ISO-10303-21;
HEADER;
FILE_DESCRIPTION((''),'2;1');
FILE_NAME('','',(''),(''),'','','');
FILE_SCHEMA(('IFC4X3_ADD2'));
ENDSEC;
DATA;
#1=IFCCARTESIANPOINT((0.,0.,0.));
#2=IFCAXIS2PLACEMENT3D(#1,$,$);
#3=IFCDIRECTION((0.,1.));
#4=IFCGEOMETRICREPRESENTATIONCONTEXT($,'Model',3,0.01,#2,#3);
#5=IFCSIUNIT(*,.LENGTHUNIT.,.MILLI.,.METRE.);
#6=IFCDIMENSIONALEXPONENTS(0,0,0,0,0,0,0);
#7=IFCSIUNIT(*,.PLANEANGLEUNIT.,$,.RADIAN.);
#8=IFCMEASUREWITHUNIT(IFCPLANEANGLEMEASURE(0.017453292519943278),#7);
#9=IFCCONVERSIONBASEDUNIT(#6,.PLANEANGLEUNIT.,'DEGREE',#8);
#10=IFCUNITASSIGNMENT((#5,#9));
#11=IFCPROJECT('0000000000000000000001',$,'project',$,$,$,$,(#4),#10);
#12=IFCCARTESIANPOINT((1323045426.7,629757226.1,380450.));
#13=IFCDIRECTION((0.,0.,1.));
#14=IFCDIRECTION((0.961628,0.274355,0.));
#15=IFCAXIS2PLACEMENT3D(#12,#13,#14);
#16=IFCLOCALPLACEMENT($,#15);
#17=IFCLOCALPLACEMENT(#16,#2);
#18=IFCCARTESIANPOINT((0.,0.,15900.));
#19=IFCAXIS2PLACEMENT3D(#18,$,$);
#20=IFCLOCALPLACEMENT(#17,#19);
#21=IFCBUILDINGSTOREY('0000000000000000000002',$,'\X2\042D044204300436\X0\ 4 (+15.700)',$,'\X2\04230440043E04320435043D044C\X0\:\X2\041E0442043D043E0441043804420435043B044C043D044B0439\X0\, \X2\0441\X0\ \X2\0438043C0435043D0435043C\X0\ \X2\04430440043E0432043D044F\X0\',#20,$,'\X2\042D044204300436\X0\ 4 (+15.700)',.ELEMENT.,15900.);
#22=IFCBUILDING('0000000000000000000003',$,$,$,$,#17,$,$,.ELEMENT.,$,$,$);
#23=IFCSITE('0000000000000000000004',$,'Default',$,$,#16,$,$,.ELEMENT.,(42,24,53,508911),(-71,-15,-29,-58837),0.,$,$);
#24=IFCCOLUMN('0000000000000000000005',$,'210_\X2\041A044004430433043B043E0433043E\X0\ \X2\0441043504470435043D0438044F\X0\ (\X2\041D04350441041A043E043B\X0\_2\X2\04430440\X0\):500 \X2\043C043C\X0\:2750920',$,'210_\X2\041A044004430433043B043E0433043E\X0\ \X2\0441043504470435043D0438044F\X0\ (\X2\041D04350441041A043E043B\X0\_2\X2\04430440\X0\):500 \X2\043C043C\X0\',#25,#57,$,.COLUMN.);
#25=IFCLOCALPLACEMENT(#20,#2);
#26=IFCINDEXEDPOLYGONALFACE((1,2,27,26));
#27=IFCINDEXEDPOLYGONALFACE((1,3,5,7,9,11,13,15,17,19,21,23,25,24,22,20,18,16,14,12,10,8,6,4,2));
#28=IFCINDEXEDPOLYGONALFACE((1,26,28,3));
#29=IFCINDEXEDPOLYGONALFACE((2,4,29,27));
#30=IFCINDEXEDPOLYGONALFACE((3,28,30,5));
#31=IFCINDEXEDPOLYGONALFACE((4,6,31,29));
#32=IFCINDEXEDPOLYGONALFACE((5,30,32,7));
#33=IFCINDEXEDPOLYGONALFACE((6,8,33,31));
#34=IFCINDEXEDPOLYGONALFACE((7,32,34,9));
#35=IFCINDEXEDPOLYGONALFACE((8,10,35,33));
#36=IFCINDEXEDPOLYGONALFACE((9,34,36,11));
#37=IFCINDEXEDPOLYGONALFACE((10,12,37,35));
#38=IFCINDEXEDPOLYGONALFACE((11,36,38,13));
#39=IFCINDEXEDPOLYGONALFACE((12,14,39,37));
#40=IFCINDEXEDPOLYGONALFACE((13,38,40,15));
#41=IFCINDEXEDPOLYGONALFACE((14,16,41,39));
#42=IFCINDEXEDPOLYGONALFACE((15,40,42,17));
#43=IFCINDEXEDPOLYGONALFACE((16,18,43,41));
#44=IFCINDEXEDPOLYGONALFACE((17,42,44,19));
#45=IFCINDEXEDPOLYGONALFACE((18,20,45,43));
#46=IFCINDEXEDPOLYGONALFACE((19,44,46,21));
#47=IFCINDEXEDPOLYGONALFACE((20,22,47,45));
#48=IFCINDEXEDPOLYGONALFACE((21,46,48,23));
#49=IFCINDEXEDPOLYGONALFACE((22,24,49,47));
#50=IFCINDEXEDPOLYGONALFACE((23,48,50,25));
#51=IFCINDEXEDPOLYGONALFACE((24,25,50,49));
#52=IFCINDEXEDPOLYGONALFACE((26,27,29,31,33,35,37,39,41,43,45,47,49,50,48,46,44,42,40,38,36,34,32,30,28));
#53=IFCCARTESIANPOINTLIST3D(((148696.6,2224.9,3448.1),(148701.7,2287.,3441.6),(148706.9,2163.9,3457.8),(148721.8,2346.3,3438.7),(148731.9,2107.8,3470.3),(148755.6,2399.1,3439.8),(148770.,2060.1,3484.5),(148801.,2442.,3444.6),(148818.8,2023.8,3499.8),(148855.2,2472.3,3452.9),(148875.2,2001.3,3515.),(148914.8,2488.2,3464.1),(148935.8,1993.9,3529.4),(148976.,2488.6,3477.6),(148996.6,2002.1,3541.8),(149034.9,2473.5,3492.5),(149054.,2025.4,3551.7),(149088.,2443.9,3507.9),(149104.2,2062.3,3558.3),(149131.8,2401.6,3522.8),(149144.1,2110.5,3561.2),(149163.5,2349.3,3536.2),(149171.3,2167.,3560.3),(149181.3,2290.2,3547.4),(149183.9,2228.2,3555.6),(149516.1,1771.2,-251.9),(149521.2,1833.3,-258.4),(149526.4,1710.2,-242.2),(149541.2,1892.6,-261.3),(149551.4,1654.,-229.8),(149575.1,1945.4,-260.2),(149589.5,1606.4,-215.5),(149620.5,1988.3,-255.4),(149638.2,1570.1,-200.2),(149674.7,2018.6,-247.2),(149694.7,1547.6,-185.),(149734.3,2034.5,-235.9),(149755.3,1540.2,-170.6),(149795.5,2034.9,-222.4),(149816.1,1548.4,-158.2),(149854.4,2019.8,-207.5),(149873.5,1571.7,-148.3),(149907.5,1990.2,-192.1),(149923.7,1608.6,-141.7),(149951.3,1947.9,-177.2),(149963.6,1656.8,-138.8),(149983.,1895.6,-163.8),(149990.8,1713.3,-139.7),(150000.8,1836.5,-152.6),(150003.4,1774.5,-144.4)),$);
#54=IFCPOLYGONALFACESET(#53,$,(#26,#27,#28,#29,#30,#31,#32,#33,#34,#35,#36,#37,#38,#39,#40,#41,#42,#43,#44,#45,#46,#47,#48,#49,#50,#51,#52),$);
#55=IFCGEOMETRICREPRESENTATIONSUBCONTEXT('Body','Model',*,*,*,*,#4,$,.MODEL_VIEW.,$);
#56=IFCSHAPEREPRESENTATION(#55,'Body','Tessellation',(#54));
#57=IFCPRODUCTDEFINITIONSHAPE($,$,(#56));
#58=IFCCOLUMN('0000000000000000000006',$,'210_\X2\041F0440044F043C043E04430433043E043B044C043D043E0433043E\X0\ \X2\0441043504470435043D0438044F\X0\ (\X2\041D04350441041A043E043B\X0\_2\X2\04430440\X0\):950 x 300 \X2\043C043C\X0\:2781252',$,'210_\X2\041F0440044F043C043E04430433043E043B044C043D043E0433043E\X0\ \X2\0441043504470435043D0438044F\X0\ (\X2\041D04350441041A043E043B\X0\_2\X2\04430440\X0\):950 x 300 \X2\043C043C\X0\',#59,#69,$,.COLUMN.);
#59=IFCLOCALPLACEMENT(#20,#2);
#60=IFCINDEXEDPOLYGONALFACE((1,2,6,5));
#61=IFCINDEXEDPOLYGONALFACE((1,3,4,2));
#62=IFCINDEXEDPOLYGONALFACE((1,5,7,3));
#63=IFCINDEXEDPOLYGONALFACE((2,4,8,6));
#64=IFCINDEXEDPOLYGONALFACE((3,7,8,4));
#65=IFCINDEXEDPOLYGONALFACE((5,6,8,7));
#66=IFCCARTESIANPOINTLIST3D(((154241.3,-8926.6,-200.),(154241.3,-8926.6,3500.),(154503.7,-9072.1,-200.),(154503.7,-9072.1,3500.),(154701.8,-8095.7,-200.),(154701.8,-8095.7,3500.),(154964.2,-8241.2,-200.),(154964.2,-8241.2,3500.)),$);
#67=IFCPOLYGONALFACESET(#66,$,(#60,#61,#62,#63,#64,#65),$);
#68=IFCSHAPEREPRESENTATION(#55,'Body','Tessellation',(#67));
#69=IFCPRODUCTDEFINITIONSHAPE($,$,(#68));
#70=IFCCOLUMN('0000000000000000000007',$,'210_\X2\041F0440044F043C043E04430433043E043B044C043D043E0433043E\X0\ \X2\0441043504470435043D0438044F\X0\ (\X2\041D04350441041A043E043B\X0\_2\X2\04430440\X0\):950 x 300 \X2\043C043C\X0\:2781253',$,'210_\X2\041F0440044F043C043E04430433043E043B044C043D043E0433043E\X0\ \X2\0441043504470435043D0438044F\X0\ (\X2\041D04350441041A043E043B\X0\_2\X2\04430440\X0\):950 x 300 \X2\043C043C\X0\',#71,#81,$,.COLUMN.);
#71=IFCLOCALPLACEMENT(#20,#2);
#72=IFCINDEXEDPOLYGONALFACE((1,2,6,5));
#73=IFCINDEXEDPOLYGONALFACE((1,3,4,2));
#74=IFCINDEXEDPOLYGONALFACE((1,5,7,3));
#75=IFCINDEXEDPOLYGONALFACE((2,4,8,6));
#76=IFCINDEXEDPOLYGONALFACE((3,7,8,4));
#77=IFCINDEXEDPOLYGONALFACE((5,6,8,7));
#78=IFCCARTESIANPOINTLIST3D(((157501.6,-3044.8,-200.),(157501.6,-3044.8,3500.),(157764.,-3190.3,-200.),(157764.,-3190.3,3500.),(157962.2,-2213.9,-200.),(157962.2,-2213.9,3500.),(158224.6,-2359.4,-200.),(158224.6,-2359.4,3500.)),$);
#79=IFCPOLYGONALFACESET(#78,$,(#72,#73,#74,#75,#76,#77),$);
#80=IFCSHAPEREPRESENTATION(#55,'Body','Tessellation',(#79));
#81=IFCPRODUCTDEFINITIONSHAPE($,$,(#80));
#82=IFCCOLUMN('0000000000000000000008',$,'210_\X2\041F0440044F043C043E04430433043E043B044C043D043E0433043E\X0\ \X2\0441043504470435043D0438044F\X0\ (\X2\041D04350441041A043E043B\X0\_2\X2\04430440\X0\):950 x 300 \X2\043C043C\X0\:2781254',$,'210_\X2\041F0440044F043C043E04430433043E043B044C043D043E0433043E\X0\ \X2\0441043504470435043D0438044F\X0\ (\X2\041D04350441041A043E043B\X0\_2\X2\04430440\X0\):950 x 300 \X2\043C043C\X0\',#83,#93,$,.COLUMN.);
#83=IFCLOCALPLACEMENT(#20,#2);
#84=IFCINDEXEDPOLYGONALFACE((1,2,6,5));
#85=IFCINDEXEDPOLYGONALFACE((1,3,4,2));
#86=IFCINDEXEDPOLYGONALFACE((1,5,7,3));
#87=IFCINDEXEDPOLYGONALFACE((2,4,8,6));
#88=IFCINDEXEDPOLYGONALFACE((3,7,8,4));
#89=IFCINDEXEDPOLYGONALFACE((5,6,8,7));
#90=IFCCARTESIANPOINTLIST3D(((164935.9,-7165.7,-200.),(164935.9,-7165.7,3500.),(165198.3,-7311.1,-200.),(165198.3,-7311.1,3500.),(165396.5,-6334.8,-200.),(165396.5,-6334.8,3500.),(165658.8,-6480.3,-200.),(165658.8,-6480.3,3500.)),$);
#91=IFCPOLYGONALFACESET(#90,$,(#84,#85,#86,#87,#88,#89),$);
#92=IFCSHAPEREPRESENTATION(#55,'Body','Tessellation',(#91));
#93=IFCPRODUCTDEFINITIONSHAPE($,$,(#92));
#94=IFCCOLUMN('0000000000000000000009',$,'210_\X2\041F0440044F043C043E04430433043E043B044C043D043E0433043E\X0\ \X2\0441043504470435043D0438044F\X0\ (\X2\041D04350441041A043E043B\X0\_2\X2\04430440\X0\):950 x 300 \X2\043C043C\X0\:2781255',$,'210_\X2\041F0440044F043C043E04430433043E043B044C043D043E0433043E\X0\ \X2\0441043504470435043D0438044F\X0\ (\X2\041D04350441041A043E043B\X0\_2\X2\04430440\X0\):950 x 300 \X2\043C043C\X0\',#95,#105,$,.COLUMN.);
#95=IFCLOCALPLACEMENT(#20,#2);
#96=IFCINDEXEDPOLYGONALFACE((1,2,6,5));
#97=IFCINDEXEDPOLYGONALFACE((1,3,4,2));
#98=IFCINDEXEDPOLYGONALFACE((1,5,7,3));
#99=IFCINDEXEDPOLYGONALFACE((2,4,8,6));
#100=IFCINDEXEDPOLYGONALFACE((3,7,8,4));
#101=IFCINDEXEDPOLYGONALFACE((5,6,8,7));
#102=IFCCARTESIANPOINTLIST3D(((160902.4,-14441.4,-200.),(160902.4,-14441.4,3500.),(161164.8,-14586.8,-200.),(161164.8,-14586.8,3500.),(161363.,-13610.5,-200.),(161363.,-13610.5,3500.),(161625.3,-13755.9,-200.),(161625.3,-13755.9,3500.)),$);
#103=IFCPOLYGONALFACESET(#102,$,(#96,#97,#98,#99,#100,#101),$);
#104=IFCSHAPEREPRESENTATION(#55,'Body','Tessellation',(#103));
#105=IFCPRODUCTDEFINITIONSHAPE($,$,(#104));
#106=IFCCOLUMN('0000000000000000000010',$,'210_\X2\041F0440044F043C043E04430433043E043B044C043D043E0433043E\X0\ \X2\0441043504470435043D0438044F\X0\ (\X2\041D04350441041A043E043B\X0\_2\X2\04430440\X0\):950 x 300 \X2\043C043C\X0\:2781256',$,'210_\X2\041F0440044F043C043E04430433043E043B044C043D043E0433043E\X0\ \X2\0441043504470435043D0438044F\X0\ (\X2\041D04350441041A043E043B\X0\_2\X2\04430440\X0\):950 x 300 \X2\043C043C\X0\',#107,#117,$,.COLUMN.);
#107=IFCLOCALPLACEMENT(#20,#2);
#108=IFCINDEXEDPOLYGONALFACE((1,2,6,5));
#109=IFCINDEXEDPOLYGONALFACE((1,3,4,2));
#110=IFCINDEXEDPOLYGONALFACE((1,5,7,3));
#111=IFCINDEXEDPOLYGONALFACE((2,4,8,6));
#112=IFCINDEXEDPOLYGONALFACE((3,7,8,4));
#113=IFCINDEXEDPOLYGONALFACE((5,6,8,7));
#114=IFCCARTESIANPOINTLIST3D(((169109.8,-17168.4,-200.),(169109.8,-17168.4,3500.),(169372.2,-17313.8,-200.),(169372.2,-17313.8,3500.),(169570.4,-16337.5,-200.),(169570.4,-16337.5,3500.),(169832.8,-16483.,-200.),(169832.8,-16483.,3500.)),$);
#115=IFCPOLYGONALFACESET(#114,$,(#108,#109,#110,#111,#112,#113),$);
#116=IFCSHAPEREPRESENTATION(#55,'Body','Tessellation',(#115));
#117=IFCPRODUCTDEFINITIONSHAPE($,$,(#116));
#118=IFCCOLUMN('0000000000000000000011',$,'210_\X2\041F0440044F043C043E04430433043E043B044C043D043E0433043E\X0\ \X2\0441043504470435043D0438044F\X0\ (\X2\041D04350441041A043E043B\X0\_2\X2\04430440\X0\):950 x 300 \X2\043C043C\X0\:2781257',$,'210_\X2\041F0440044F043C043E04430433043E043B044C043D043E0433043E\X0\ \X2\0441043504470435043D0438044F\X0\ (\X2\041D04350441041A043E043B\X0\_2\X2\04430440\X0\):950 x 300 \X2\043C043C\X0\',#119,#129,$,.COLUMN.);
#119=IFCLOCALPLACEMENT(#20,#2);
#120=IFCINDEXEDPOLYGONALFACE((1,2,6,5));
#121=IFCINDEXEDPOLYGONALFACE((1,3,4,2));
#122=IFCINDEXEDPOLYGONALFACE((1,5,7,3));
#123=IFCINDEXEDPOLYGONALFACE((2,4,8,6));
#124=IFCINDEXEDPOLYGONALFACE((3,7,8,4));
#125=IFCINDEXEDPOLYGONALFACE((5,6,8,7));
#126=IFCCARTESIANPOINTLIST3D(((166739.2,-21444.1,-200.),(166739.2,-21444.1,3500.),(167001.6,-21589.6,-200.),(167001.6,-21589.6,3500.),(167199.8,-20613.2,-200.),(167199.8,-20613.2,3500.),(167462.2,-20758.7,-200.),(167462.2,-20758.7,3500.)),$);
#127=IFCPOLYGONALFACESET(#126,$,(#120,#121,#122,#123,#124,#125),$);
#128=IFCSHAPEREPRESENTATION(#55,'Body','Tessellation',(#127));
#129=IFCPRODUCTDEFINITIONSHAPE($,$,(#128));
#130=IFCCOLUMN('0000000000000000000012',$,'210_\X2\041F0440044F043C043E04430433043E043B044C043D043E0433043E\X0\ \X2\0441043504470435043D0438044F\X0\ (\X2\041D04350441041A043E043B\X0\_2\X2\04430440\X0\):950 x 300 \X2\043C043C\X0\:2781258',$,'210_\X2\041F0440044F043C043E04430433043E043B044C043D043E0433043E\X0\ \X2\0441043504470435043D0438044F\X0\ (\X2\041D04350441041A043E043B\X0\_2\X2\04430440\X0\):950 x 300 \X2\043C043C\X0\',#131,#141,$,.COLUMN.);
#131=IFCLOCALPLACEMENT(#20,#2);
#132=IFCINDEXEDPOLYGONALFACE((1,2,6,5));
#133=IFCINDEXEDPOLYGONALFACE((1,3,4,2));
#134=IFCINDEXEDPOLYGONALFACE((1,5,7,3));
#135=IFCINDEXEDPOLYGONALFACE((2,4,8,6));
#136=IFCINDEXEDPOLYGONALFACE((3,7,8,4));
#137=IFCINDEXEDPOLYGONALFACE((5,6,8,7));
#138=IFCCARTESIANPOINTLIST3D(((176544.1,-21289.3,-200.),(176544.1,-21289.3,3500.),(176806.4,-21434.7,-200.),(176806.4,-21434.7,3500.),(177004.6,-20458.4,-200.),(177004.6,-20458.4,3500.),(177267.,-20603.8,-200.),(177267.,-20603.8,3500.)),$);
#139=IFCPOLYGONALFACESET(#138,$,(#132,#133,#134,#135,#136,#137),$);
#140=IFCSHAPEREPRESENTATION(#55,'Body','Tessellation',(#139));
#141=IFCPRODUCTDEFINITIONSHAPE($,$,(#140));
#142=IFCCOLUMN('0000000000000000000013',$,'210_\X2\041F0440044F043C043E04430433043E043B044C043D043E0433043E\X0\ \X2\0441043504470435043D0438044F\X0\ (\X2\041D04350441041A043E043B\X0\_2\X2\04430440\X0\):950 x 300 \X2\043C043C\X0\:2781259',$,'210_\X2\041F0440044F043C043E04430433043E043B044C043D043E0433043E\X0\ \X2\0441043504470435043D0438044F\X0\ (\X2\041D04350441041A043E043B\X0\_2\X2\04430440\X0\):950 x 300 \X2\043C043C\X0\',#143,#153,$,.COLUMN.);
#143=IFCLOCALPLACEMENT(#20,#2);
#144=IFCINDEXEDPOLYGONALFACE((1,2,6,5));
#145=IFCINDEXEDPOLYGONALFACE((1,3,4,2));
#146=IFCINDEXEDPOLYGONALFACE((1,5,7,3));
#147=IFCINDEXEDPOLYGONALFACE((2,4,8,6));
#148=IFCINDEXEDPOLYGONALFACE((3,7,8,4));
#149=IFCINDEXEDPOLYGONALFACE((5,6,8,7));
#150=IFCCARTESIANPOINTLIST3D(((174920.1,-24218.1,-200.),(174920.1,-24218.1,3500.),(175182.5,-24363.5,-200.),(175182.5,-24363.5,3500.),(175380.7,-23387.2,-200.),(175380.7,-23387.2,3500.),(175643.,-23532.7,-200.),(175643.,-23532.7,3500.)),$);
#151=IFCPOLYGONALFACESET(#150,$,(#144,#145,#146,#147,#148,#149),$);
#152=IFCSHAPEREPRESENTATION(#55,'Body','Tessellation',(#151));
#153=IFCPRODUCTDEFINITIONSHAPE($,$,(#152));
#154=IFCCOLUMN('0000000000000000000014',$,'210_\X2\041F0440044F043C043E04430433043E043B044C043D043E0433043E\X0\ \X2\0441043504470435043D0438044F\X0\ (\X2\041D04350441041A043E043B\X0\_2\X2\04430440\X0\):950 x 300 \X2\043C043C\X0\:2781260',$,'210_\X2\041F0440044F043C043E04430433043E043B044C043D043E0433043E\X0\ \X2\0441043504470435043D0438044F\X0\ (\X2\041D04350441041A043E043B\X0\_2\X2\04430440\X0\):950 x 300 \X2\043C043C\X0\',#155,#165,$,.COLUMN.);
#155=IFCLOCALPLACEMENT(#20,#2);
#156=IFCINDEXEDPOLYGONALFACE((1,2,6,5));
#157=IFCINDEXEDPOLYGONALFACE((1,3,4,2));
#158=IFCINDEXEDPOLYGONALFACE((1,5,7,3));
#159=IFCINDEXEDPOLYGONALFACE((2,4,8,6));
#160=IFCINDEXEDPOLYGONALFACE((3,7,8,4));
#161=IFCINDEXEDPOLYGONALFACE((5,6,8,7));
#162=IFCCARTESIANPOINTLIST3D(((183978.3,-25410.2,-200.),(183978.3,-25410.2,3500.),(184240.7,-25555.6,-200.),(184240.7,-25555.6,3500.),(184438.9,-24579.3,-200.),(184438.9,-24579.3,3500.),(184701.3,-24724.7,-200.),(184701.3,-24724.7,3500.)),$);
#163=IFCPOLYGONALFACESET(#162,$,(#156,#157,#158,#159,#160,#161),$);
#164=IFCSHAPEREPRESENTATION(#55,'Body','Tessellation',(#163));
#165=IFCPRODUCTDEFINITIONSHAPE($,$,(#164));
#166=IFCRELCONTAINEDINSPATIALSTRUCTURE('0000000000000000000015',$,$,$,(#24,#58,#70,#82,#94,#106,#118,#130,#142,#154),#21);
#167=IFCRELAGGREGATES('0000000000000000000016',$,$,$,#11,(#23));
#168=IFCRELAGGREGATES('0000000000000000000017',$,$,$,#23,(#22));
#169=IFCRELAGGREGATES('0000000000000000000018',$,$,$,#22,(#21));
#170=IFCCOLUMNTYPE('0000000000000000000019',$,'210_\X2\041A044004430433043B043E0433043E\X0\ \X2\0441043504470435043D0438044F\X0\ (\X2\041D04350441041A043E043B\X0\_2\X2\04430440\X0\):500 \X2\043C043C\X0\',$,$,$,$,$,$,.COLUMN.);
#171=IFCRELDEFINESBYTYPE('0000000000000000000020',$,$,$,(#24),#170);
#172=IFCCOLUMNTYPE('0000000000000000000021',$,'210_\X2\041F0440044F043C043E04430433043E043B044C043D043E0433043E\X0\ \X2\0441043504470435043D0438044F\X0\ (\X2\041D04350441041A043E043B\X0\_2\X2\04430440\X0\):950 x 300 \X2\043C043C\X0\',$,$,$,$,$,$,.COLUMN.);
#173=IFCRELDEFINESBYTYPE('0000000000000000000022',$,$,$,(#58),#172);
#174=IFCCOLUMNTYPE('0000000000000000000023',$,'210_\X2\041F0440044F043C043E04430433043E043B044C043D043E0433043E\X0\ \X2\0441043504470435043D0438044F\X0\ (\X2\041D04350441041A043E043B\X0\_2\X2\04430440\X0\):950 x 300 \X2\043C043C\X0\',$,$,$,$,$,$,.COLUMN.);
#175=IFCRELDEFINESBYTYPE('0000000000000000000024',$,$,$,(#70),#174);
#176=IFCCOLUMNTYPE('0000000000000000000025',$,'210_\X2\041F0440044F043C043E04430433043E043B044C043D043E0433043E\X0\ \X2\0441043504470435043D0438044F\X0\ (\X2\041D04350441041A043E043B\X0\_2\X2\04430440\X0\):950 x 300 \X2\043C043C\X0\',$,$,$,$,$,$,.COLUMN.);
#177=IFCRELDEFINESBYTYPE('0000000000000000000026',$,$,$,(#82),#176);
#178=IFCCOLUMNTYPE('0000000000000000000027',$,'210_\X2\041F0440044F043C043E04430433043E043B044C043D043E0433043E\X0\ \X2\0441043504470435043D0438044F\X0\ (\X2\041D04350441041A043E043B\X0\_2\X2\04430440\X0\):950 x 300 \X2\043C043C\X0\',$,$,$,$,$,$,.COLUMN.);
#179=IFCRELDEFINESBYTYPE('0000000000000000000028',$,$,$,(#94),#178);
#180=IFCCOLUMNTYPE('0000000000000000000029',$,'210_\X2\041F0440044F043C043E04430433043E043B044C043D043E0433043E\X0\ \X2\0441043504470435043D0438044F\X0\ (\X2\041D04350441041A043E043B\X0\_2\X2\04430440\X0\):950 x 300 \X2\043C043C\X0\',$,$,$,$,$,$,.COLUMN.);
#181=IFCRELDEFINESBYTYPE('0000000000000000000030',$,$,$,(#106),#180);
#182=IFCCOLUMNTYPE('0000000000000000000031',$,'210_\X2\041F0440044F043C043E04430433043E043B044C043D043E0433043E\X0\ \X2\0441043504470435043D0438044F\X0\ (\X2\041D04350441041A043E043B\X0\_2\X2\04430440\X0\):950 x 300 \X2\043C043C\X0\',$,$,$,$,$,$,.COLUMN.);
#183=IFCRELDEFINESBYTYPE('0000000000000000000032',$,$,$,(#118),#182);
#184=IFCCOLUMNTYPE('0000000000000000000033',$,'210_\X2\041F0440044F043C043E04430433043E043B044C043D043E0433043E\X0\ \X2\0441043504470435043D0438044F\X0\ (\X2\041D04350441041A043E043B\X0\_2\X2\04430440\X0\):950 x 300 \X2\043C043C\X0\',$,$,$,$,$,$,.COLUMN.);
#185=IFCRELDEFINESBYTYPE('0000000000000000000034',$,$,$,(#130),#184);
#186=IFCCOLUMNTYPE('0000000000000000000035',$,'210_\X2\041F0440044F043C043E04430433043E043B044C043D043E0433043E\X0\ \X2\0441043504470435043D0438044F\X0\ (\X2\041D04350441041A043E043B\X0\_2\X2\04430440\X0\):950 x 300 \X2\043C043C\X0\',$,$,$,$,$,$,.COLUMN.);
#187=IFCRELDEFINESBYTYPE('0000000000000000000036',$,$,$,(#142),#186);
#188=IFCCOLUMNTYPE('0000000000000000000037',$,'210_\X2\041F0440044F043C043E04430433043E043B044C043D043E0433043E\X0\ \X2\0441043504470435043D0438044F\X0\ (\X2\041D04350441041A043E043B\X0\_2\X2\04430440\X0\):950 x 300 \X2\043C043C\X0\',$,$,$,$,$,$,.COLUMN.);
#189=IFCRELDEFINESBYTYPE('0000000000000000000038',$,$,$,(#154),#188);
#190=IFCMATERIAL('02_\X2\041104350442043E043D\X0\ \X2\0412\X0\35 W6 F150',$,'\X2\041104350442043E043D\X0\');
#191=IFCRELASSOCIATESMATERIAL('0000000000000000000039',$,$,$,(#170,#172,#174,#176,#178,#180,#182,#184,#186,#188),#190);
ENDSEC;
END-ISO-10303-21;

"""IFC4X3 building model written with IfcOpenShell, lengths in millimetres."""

from ifc_helpers import new_model, entity, si_unit, converted_unit, direction, frame, frame_2d, origin, origin_2d_with_axis, place, context, subcontext, project, spatial, rectangle, circle, extrude, source, transform, mapped, material, material_profile, profile_set, type_object, type_shapes, element, save


model = new_model("IFC4X3")

# Units and contexts
model_context = context("Model", 3, precision=0.01, world=origin(), true_north=direction((0.0, 1.0)))
body_context = subcontext(model_context, "Body", "Model", "MODEL_VIEW")
ifc_project = project(units=[si_unit("LENGTHUNIT", "METRE", prefix="MILLI"), converted_unit("PLANEANGLEUNIT", "DEGREE", entity("IfcPlaneAngleMeasure", 0.017453292519943278), si_unit("PLANEANGLEUNIT", "RADIAN"), dimensions=[0, 0, 0, 0, 0, 0, 0])], contexts=[model_context])

# Site, building, storey
site_placement = place(None, frame((1323045426.7, 629757226.1, 380450.0), z_axis=(0.0, 0.0, 1.0), x_axis=(0.961628, 0.274355, 0.0)))
site = spatial("IfcSite", under=ifc_project, at=site_placement, Name="Default", CompositionType="ELEMENT", RefLatitude=(42, 24, 53, 508911), RefLongitude=(-71, -15, -29, -58837), RefElevation=0.0)
building_placement = place(site_placement, origin())
building = spatial("IfcBuilding", under=site, at=building_placement, CompositionType="ELEMENT")
storey_placement = place(building_placement, frame((0.0, 0.0, 15900.0)))
storey = spatial("IfcBuildingStorey", under=building, at=storey_placement, Name="Этаж 4 (+15.700)", ObjectType="Уровень:Относительный, с именем уровня", LongName="Этаж 4 (+15.700)", CompositionType="ELEMENT", Elevation=15900.0)

# Columns
ifc_material = material(Name="02_Бетон В35 W6 F150", Category="Бетон")
ifc_material_profile_1 = material_profile(ifc_material, circle(Radius=250.0, at=origin_2d_with_axis()), Name="500 мм")
ifc_profile_set_1 = profile_set([ifc_material_profile_1], Name="500 мм")
column_type_1 = type_object("IfcColumnType", Name="210_Круглого сечения (НесКол_2ур):500 мм", PredefinedType="COLUMN", material=ifc_profile_set_1)
shared_shape_1 = source(origin(), body_context, "Body", "SweptSolid", [
    extrude(circle(Radius=250.0, at=origin_2d_with_axis()), frame((149760.1, 1788.4, 15700.0), z_axis=(-0.21471, 0.118874, 0.969417), x_axis=(-0.834808, -0.53753, -0.118982)), (0.0, 0.0, 1.0), 3816.7),
])
type_shapes(column_type_1, [shared_shape_1])
column_1_placement = place(storey_placement, frame((0.0, 0.0, -15900.0)))
element("IfcColumn", 1, at=column_1_placement, inside=storey, type_object=column_type_1, Name="210_Круглого сечения (НесКол_2ур):500 мм:2750920", ObjectType="210_Круглого сечения (НесКол_2ур):500 мм", PredefinedType="COLUMN", context=body_context, shape_type="MappedRepresentation", body=[
    mapped(shared_shape_1, transform((0.0, 0.0, 0.0), scale=1.0)),
])
ifc_material_profile_2 = material_profile(ifc_material, rectangle(XDim=300.0, YDim=950.0, at=frame_2d((0.0, 0.0), x_axis=(1.0, 0.0))), Name="950 x 300 мм")
ifc_profile_set_2 = profile_set([ifc_material_profile_2], Name="950 x 300 мм")
column_type_2 = type_object("IfcColumnType", Name="210_Прямоугольного сечения (НесКол_2ур):950 x 300 мм", PredefinedType="COLUMN", material=ifc_profile_set_2)
shared_shape_2 = source(origin(), body_context, "Body", "SweptSolid", [
    extrude(rectangle(XDim=300.0, YDim=950.0, at=frame_2d((0.0, 0.0), x_axis=(1.0, 0.0))), frame((154602.7, -8583.9, 15700.0), z_axis=(0.0, 0.0, 1.0), x_axis=(-0.87462, 0.48481, 0.0)), (0.0, 0.0, 1.0), 3700.0),
])
type_shapes(column_type_2, [shared_shape_2])
column_2_placement = place(storey_placement, frame((0.0, 0.0, -15900.0)))
element("IfcColumn", 2, at=column_2_placement, inside=storey, type_object=column_type_2, Name="210_Прямоугольного сечения (НесКол_2ур):950 x 300 мм:2781252", ObjectType="210_Прямоугольного сечения (НесКол_2ур):950 x 300 мм", PredefinedType="COLUMN", context=body_context, shape_type="MappedRepresentation", body=[
    mapped(shared_shape_2, transform((0.0, 0.0, 0.0), scale=1.0)),
])
column_type_3 = type_object("IfcColumnType", Name="210_Прямоугольного сечения (НесКол_2ур):950 x 300 мм", PredefinedType="COLUMN", material=ifc_profile_set_2)
shared_shape_3 = source(origin(), body_context, "Body", "SweptSolid", [
    extrude(rectangle(XDim=300.0, YDim=950.0, at=frame_2d((0.0, 0.0), x_axis=(1.0, 0.0))), frame((157863.1, -2702.1, 15700.0), z_axis=(0.0, 0.0, 1.0), x_axis=(-0.87462, 0.48481, 0.0)), (0.0, 0.0, 1.0), 3700.0),
])
type_shapes(column_type_3, [shared_shape_3])
column_3_placement = place(storey_placement, frame((0.0, 0.0, -15900.0)))
element("IfcColumn", 3, at=column_3_placement, inside=storey, type_object=column_type_3, Name="210_Прямоугольного сечения (НесКол_2ур):950 x 300 мм:2781253", ObjectType="210_Прямоугольного сечения (НесКол_2ур):950 x 300 мм", PredefinedType="COLUMN", context=body_context, shape_type="MappedRepresentation", body=[
    mapped(shared_shape_3, transform((0.0, 0.0, 0.0), scale=1.0)),
])
column_type_4 = type_object("IfcColumnType", Name="210_Прямоугольного сечения (НесКол_2ур):950 x 300 мм", PredefinedType="COLUMN", material=ifc_profile_set_2)
shared_shape_4 = source(origin(), body_context, "Body", "SweptSolid", [
    extrude(rectangle(XDim=300.0, YDim=950.0, at=frame_2d((0.0, 0.0), x_axis=(1.0, 0.0))), frame((165297.4, -6823.0, 15700.0), z_axis=(0.0, 0.0, 1.0), x_axis=(-0.87462, 0.48481, 0.0)), (0.0, 0.0, 1.0), 3700.0),
])
type_shapes(column_type_4, [shared_shape_4])
column_4_placement = place(storey_placement, frame((0.0, 0.0, -15900.0)))
element("IfcColumn", 4, at=column_4_placement, inside=storey, type_object=column_type_4, Name="210_Прямоугольного сечения (НесКол_2ур):950 x 300 мм:2781254", ObjectType="210_Прямоугольного сечения (НесКол_2ур):950 x 300 мм", PredefinedType="COLUMN", context=body_context, shape_type="MappedRepresentation", body=[
    mapped(shared_shape_4, transform((0.0, 0.0, 0.0), scale=1.0)),
])
column_type_5 = type_object("IfcColumnType", Name="210_Прямоугольного сечения (НесКол_2ур):950 x 300 мм", PredefinedType="COLUMN", material=ifc_profile_set_2)
shared_shape_5 = source(origin(), body_context, "Body", "SweptSolid", [
    extrude(rectangle(XDim=300.0, YDim=950.0, at=frame_2d((0.0, 0.0), x_axis=(1.0, 0.0))), frame((161263.9, -14098.7, 15700.0), z_axis=(0.0, 0.0, 1.0), x_axis=(-0.87462, 0.48481, 0.0)), (0.0, 0.0, 1.0), 3700.0),
])
type_shapes(column_type_5, [shared_shape_5])
column_5_placement = place(storey_placement, frame((0.0, 0.0, -15900.0)))
element("IfcColumn", 5, at=column_5_placement, inside=storey, type_object=column_type_5, Name="210_Прямоугольного сечения (НесКол_2ур):950 x 300 мм:2781255", ObjectType="210_Прямоугольного сечения (НесКол_2ур):950 x 300 мм", PredefinedType="COLUMN", context=body_context, shape_type="MappedRepresentation", body=[
    mapped(shared_shape_5, transform((0.0, 0.0, 0.0), scale=1.0)),
])
column_type_6 = type_object("IfcColumnType", Name="210_Прямоугольного сечения (НесКол_2ур):950 x 300 мм", PredefinedType="COLUMN", material=ifc_profile_set_2)
shared_shape_6 = source(origin(), body_context, "Body", "SweptSolid", [
    extrude(rectangle(XDim=300.0, YDim=950.0, at=origin_2d_with_axis()), frame((169471.3, -16825.7, 15700.0), z_axis=(0.0, 0.0, 1.0), x_axis=(-0.87462, 0.48481, 0.0)), (0.0, 0.0, 1.0), 3700.0),
])
type_shapes(column_type_6, [shared_shape_6])
column_6_placement = place(storey_placement, frame((0.0, 0.0, -15900.0)))
element("IfcColumn", 6, at=column_6_placement, inside=storey, type_object=column_type_6, Name="210_Прямоугольного сечения (НесКол_2ур):950 x 300 мм:2781256", ObjectType="210_Прямоугольного сечения (НесКол_2ур):950 x 300 мм", PredefinedType="COLUMN", context=body_context, shape_type="MappedRepresentation", body=[
    mapped(shared_shape_6, transform((0.0, 0.0, 0.0), scale=1.0)),
])
column_type_7 = type_object("IfcColumnType", Name="210_Прямоугольного сечения (НесКол_2ур):950 x 300 мм", PredefinedType="COLUMN", material=ifc_profile_set_2)
shared_shape_7 = source(origin(), body_context, "Body", "SweptSolid", [
    extrude(rectangle(XDim=300.0, YDim=950.0, at=origin_2d_with_axis()), frame((167100.7, -21101.4, 15700.0), z_axis=(0.0, 0.0, 1.0), x_axis=(-0.87462, 0.48481, 0.0)), (0.0, 0.0, 1.0), 3700.0),
])
type_shapes(column_type_7, [shared_shape_7])
column_7_placement = place(storey_placement, frame((0.0, 0.0, -15900.0)))
element("IfcColumn", 7, at=column_7_placement, inside=storey, type_object=column_type_7, Name="210_Прямоугольного сечения (НесКол_2ур):950 x 300 мм:2781257", ObjectType="210_Прямоугольного сечения (НесКол_2ур):950 x 300 мм", PredefinedType="COLUMN", context=body_context, shape_type="MappedRepresentation", body=[
    mapped(shared_shape_7, transform((0.0, 0.0, 0.0), scale=1.0)),
])
column_type_8 = type_object("IfcColumnType", Name="210_Прямоугольного сечения (НесКол_2ур):950 x 300 мм", PredefinedType="COLUMN", material=ifc_profile_set_2)
shared_shape_8 = source(origin(), body_context, "Body", "SweptSolid", [
    extrude(rectangle(XDim=300.0, YDim=950.0, at=origin_2d_with_axis()), frame((176905.5, -20946.6, 15700.0), z_axis=(0.0, 0.0, 1.0), x_axis=(-0.87462, 0.48481, 0.0)), (0.0, 0.0, 1.0), 3700.0),
])
type_shapes(column_type_8, [shared_shape_8])
column_8_placement = place(storey_placement, frame((0.0, 0.0, -15900.0)))
element("IfcColumn", 8, at=column_8_placement, inside=storey, type_object=column_type_8, Name="210_Прямоугольного сечения (НесКол_2ур):950 x 300 мм:2781258", ObjectType="210_Прямоугольного сечения (НесКол_2ур):950 x 300 мм", PredefinedType="COLUMN", context=body_context, shape_type="MappedRepresentation", body=[
    mapped(shared_shape_8, transform((0.0, 0.0, 0.0), scale=1.0)),
])
column_type_9 = type_object("IfcColumnType", Name="210_Прямоугольного сечения (НесКол_2ур):950 x 300 мм", PredefinedType="COLUMN", material=ifc_profile_set_2)
shared_shape_9 = source(origin(), body_context, "Body", "SweptSolid", [
    extrude(rectangle(XDim=300.0, YDim=950.0, at=frame_2d((0.0, 0.0), x_axis=(1.0, 0.0))), frame((175281.6, -23875.4, 15700.0), z_axis=(0.0, 0.0, 1.0), x_axis=(-0.87462, 0.48481, 0.0)), (0.0, 0.0, 1.0), 3700.0),
])
type_shapes(column_type_9, [shared_shape_9])
column_9_placement = place(storey_placement, frame((0.0, 0.0, -15900.0)))
element("IfcColumn", 9, at=column_9_placement, inside=storey, type_object=column_type_9, Name="210_Прямоугольного сечения (НесКол_2ур):950 x 300 мм:2781259", ObjectType="210_Прямоугольного сечения (НесКол_2ур):950 x 300 мм", PredefinedType="COLUMN", context=body_context, shape_type="MappedRepresentation", body=[
    mapped(shared_shape_9, transform((0.0, 0.0, 0.0), scale=1.0)),
])
column_type_10 = type_object("IfcColumnType", Name="210_Прямоугольного сечения (НесКол_2ур):950 x 300 мм", PredefinedType="COLUMN", material=ifc_profile_set_2)
shared_shape_10 = source(origin(), body_context, "Body", "SweptSolid", [
    extrude(rectangle(XDim=300.0, YDim=950.0, at=frame_2d((0.0, 0.0), x_axis=(1.0, 0.0))), frame((184339.8, -25067.5, 15700.0), z_axis=(0.0, 0.0, 1.0), x_axis=(-0.87462, 0.48481, 0.0)), (0.0, 0.0, 1.0), 3700.0),
])
type_shapes(column_type_10, [shared_shape_10])
column_10_placement = place(storey_placement, frame((0.0, 0.0, -15900.0)))
element("IfcColumn", 10, at=column_10_placement, inside=storey, type_object=column_type_10, Name="210_Прямоугольного сечения (НесКол_2ур):950 x 300 мм:2781260", ObjectType="210_Прямоугольного сечения (НесКол_2ур):950 x 300 мм", PredefinedType="COLUMN", context=body_context, shape_type="MappedRepresentation", body=[
    mapped(shared_shape_10, transform((0.0, 0.0, 0.0), scale=1.0)),
])

save(model, "model.ifc")
